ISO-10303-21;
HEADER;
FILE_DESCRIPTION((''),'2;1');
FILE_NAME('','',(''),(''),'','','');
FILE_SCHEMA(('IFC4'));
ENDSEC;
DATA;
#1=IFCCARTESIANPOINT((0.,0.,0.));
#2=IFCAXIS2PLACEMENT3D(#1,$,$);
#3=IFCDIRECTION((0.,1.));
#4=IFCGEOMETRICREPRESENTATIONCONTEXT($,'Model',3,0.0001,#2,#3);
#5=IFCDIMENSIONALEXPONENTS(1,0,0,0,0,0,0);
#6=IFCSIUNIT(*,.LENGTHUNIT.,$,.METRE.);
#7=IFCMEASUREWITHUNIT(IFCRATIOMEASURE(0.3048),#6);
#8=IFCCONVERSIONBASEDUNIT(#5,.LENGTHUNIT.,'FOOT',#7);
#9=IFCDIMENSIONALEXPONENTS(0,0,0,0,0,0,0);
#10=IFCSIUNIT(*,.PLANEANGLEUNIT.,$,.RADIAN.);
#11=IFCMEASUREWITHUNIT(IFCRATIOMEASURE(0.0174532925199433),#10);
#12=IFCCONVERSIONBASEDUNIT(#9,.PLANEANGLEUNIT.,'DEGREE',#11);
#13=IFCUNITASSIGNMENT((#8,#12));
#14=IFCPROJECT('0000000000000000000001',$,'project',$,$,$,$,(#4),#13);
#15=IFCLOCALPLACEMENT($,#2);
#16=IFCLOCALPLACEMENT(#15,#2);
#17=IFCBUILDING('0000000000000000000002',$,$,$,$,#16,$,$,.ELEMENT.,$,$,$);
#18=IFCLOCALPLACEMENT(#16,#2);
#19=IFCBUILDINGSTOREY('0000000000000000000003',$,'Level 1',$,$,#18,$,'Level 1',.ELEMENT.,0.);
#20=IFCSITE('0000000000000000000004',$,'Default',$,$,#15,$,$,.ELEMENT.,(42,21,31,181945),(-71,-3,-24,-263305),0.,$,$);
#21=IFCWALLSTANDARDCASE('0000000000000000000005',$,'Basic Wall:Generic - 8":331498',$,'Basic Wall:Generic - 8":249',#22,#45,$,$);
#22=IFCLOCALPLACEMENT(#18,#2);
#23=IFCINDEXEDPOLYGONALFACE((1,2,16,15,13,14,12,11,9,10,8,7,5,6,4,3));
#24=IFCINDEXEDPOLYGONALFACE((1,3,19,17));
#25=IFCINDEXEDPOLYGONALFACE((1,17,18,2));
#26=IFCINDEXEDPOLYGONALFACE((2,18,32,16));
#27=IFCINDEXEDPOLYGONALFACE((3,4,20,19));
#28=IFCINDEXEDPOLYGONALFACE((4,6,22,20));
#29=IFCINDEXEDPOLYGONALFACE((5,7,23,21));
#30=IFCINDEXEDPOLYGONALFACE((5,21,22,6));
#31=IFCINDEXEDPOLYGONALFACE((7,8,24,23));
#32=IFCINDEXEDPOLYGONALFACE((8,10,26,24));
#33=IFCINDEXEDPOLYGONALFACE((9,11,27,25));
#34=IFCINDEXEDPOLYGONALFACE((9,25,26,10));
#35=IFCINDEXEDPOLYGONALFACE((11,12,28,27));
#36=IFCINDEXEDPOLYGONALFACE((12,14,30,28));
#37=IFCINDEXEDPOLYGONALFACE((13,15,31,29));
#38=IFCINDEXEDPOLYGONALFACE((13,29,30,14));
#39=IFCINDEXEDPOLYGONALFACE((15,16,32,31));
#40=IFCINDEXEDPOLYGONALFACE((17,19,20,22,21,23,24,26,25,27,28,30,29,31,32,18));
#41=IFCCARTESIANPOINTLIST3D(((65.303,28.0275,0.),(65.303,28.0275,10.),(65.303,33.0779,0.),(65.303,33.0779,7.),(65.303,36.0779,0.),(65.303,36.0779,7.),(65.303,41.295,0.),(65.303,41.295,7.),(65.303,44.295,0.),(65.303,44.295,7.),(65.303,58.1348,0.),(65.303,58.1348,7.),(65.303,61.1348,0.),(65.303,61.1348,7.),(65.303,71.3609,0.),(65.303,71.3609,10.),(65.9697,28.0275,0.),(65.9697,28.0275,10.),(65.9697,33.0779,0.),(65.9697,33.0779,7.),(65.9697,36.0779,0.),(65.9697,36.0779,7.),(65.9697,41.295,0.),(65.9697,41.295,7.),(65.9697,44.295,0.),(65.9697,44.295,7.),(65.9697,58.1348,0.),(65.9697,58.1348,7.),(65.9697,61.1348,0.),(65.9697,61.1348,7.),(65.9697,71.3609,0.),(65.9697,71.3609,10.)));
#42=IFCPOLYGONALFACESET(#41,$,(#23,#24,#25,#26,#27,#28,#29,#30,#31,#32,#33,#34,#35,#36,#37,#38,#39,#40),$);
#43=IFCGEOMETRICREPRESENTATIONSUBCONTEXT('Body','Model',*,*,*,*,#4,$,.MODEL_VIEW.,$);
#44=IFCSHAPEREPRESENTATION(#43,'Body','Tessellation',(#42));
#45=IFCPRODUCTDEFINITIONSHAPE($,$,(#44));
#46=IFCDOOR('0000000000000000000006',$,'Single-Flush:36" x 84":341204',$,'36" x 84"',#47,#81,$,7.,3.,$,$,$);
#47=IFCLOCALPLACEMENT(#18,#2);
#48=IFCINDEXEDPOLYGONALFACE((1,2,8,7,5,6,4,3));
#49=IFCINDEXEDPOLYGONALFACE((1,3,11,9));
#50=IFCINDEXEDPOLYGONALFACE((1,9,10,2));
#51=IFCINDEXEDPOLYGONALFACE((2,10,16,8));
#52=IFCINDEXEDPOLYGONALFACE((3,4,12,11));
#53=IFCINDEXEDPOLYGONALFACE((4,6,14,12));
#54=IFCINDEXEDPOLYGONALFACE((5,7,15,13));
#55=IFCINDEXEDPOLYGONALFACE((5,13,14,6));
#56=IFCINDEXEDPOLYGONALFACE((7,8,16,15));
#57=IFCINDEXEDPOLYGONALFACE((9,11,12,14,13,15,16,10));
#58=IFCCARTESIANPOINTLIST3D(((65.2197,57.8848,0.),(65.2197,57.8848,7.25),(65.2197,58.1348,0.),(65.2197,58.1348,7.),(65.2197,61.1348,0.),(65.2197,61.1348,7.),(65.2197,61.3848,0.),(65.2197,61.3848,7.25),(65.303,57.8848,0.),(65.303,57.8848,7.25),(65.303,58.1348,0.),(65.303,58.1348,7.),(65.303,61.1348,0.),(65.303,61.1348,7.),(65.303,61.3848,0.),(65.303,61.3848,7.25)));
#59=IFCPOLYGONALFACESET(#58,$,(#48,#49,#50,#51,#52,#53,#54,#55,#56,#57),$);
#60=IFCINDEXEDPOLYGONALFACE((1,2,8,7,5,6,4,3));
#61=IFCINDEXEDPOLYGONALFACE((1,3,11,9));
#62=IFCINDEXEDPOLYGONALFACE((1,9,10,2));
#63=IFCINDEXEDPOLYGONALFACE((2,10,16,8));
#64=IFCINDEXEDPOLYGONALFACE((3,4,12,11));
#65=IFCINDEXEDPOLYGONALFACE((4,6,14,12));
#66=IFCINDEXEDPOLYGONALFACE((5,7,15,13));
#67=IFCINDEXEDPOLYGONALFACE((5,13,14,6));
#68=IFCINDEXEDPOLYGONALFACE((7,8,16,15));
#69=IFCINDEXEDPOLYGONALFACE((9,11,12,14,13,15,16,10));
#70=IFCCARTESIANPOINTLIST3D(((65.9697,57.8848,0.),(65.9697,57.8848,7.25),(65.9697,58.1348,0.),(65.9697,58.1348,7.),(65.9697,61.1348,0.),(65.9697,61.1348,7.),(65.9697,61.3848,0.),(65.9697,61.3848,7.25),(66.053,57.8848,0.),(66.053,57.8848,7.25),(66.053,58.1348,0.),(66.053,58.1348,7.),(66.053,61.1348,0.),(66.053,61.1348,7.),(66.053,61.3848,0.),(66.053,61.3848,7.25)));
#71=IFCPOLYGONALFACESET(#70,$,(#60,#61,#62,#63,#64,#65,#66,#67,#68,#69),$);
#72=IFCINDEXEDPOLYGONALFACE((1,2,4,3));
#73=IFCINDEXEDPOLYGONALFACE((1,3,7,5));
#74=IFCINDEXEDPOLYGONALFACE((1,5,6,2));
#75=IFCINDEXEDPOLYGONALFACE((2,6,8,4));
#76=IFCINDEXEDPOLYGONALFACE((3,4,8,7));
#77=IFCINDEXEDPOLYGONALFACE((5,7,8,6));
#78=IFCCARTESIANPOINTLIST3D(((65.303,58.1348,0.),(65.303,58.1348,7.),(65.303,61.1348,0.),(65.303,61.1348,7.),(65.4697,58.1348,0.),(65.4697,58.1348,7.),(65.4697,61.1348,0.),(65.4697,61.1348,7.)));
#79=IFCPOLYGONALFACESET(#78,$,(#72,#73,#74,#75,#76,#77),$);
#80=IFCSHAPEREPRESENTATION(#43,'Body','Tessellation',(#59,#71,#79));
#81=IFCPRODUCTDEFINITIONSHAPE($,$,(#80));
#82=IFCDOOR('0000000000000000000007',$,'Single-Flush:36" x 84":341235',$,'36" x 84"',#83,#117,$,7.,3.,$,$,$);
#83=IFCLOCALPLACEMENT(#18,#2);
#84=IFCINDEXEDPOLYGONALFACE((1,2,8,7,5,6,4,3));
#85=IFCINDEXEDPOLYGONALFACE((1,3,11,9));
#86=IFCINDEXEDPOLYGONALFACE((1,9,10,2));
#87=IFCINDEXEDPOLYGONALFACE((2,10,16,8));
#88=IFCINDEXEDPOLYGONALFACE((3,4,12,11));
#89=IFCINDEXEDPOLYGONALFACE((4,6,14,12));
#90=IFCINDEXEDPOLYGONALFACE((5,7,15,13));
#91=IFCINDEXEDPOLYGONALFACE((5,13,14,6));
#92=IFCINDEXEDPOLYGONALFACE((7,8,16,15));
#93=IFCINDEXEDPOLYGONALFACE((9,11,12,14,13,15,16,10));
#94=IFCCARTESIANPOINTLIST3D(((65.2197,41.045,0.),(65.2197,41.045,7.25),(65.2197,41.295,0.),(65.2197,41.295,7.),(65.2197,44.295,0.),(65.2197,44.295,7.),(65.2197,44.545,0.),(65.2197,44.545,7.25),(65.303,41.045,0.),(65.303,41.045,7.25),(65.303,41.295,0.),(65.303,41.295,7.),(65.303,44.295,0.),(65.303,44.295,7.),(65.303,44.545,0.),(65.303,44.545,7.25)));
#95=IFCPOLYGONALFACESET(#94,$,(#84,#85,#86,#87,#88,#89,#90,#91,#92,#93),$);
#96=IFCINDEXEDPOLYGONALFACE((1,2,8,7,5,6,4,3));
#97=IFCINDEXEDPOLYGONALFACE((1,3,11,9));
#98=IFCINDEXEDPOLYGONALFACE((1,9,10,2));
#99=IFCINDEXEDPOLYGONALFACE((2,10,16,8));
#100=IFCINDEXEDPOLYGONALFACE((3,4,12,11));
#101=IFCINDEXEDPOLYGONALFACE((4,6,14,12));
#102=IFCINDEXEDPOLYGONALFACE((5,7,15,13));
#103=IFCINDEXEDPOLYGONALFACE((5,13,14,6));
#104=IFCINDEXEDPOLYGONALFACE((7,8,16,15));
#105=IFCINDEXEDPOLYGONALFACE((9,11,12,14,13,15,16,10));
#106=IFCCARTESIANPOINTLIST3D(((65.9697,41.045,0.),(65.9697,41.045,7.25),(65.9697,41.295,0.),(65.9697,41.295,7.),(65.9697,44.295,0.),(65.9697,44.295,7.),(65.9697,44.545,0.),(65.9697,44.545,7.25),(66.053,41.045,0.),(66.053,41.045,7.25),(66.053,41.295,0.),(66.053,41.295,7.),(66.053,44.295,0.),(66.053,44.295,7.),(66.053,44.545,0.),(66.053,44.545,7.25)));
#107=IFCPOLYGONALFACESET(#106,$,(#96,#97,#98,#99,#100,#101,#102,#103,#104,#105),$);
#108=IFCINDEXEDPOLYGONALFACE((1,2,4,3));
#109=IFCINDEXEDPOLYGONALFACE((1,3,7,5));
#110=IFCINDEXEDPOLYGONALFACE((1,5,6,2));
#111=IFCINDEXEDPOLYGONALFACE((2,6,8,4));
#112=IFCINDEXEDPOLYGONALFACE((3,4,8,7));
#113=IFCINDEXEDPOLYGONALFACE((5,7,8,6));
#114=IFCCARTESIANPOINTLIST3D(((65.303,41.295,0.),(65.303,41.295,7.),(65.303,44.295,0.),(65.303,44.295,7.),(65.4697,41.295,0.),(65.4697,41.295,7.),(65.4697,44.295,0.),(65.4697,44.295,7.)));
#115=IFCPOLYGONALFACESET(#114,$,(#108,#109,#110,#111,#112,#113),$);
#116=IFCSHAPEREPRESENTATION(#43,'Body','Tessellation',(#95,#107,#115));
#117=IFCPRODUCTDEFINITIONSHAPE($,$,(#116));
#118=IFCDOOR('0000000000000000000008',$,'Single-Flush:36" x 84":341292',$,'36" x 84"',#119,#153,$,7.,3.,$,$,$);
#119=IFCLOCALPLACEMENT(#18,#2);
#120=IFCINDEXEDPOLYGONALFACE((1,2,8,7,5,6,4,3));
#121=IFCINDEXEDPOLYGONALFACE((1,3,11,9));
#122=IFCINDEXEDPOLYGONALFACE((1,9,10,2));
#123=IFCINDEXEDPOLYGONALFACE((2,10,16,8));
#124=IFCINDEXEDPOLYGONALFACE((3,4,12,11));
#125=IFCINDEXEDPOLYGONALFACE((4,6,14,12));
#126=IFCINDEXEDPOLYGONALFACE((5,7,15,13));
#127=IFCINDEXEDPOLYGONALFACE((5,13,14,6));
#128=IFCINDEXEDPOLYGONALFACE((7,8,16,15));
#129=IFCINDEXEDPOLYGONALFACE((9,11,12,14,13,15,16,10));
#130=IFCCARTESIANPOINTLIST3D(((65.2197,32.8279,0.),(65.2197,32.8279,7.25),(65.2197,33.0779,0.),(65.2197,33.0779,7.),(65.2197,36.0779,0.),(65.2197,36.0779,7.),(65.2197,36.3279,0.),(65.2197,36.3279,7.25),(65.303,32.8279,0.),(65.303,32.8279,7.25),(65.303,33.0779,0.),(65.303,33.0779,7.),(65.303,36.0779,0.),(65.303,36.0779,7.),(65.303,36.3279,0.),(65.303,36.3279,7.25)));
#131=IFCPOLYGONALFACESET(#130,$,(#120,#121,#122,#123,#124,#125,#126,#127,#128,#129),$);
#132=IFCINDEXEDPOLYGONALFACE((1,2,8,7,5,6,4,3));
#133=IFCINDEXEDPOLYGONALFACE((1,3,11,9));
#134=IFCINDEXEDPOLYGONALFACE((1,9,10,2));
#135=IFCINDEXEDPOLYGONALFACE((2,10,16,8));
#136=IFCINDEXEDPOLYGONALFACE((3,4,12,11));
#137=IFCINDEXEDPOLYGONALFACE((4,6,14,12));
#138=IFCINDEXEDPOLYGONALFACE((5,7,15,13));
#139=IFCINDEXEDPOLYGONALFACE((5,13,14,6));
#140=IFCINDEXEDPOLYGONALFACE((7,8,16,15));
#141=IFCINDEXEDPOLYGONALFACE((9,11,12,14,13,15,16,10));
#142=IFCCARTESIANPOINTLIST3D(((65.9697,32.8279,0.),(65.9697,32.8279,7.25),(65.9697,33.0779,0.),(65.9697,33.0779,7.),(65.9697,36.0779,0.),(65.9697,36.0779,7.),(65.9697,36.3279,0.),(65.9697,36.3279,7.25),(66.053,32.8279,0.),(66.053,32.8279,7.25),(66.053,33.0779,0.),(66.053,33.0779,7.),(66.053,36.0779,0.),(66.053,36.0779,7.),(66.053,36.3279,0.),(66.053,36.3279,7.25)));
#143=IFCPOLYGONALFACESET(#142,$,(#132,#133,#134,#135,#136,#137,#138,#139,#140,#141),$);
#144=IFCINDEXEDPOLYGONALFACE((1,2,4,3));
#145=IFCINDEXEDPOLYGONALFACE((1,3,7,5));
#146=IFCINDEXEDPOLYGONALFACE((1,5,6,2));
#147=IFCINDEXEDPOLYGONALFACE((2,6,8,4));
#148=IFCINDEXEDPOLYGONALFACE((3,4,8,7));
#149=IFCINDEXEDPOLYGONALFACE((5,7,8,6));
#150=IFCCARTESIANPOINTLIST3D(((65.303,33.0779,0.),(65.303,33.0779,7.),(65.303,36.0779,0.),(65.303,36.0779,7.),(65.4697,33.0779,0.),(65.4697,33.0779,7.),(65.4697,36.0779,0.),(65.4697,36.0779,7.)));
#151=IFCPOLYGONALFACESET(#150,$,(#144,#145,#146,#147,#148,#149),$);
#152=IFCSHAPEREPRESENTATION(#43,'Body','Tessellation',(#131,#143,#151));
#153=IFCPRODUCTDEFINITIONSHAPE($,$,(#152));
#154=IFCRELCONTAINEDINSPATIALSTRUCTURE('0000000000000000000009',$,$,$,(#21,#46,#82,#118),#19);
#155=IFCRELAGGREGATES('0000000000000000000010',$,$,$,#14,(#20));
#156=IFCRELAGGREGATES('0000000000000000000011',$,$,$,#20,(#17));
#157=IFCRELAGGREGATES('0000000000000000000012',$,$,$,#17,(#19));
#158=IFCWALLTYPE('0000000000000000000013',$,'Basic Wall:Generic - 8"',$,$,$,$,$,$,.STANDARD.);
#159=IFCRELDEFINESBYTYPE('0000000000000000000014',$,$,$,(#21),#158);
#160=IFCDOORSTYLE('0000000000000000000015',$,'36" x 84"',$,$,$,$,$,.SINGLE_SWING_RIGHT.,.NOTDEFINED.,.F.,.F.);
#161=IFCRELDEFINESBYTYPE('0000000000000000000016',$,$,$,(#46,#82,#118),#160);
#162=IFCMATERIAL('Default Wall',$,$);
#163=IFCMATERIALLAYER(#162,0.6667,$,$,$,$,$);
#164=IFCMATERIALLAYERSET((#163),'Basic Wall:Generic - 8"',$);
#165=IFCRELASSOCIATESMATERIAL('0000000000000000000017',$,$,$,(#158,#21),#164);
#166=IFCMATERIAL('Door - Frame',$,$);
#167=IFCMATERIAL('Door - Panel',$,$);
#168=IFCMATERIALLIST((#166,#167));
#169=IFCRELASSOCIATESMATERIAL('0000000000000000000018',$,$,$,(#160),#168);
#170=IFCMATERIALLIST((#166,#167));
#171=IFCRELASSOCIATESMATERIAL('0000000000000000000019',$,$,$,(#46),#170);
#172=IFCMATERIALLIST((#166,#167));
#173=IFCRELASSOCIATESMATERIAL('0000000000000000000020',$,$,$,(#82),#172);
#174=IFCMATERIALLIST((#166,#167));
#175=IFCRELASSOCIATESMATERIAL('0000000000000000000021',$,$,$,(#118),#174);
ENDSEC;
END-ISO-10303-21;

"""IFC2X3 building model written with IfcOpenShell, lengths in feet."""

from ifc_helpers import new_model, entity, si_unit, converted_unit, direction, frame, frame_2d, origin, place, context, subcontext, project, spatial, polyline, rectangle, outline, extrude, source, transform, mapped, material, material_list, layer, layer_set, layer_usage, type_object, type_shapes, element, fill, save


model = new_model("IFC2X3")

# Units and contexts
model_context = context("Model", 3, precision=0.0001, world=origin(), true_north=direction((0.0, 1.0)))
body_context = subcontext(model_context, "Body", "Model", "MODEL_VIEW")
ifc_project = project(units=[converted_unit("LENGTHUNIT", "FOOT", entity("IfcRatioMeasure", 0.3048), si_unit("LENGTHUNIT", "METRE"), dimensions=[1, 0, 0, 0, 0, 0, 0]), converted_unit("PLANEANGLEUNIT", "DEGREE", entity("IfcRatioMeasure", 0.0174532925199433), si_unit("PLANEANGLEUNIT", "RADIAN"), dimensions=[0, 0, 0, 0, 0, 0, 0])], contexts=[model_context])

# Site, building, storey
site_placement = place(None, origin())
site = spatial("IfcSite", under=ifc_project, at=site_placement, Name="Default", CompositionType="ELEMENT", RefLatitude=(42, 21, 31, 181945), RefLongitude=(-71, -3, -24, -263305), RefElevation=0.0)
building_placement = place(site_placement, origin())
building = spatial("IfcBuilding", under=site, at=building_placement, CompositionType="ELEMENT")
storey_placement = place(building_placement, origin())
storey = spatial("IfcBuildingStorey", under=building, at=storey_placement, Name="Level 1", LongName="Level 1", CompositionType="ELEMENT", Elevation=0.0)

# Wall, openings, doors
ifc_material_1 = material(Name="Default Wall")
ifc_layer = layer(ifc_material_1, 0.6667)
ifc_layer_set = layer_set([ifc_layer], Name="Basic Wall:Generic - 8\"")
ifc_layer_usage_1 = layer_usage(ifc_layer_set, "AXIS2", "NEGATIVE", 0.3333)
wall_type = type_object("IfcWallType", Name="Basic Wall:Generic - 8\"", PredefinedType="STANDARD", material=ifc_layer_set)
wall_1_placement = place(storey_placement, frame((65.6363, 28.0275, 0.0), z_axis=(0.0, 0.0, 1.0), x_axis=(0.0, 1.0, 0.0)))
wall_1 = element("IfcWallStandardCase", 1, at=wall_1_placement, inside=storey, type_object=wall_type, material=ifc_layer_usage_1, Name="Basic Wall:Generic - 8\":331498", ObjectType="Basic Wall:Generic - 8\":249", context=body_context, shape_type="SweptSolid", body=[
    extrude(rectangle(XDim=43.3333, YDim=0.6667, at=frame_2d((21.6667, 0.0), x_axis=(-1.0, 0.0))), origin(), (0.0, 0.0, 1.0), 10.0),
])
opening_1_placement = place(wall_1_placement, frame((30.1072, -0.3333, 0.0)))
opening_1 = element("IfcOpeningElement", 2, at=opening_1_placement, cuts=wall_1, ObjectType="Opening", context=body_context, shape_type="SweptSolid", body=[
    extrude(rectangle(XDim=3.0, YDim=7.0, at=frame_2d((3.5, 1.5), x_axis=(0.0, 1.0))), frame((0.0, 0.0, 0.0), z_axis=(0.0, 1.0, 0.0), x_axis=(0.0, 0.0, 1.0)), (0.0, 0.0, 1.0), 0.6667),
])
opening_2_placement = place(wall_1_placement, frame((13.2675, -0.3333, 0.0)))
opening_2 = element("IfcOpeningElement", 3, at=opening_2_placement, cuts=wall_1, ObjectType="Opening", context=body_context, shape_type="SweptSolid", body=[
    extrude(rectangle(XDim=3.0, YDim=7.0, at=frame_2d((3.5, 1.5), x_axis=(0.0, 1.0))), frame((0.0, 0.0, 0.0), z_axis=(0.0, 1.0, 0.0), x_axis=(0.0, 0.0, 1.0)), (0.0, 0.0, 1.0), 0.6667),
])
opening_3_placement = place(wall_1_placement, frame((5.0504, -0.3333, 0.0)))
opening_3 = element("IfcOpeningElement", 4, at=opening_3_placement, cuts=wall_1, ObjectType="Opening", context=body_context, shape_type="SweptSolid", body=[
    extrude(rectangle(XDim=3.0, YDim=7.0, at=frame_2d((3.5, 1.5), x_axis=(0.0, 1.0))), frame((0.0, 0.0, 0.0), z_axis=(0.0, 1.0, 0.0), x_axis=(0.0, 0.0, 1.0)), (0.0, 0.0, 1.0), 0.6667),
])
ifc_material_2 = material(Name="Door - Frame")
ifc_material_3 = material(Name="Door - Panel")
ifc_material_list_1 = material_list([ifc_material_2, ifc_material_3])
ifc_material_list_2 = material_list([ifc_material_2, ifc_material_3])
door_style = type_object("IfcDoorStyle", Name="36\" x 84\"", ConstructionType="NOTDEFINED", OperationType="SINGLE_SWING_RIGHT", ParameterTakesPrecedence=False, Sizeable=False, material=ifc_material_list_2)
shared_shape = source(origin(), body_context, "Body", "SweptSolid", [
    extrude(outline(polyline([(-1.75, -3.6875), (1.75, -3.6875), (1.75, 3.5625), (1.5, 3.5625), (1.5, -3.4375), (-1.5, -3.4375), (-1.5, 3.5625), (-1.75, 3.5625), (-1.75, -3.6875)])), frame((1.5, 0.6667, 3.5625), z_axis=(0.0, 1.0, 0.0), x_axis=(1.0, 0.0, 0.0)), (0.0, 0.0, 1.0), 0.0833),
    extrude(outline(polyline([(-3.6875, -1.75), (3.5625, -1.75), (3.5625, -1.5), (-3.4375, -1.5), (-3.4375, 1.5), (3.5625, 1.5), (3.5625, 1.75), (-3.6875, 1.75), (-3.6875, -1.75)])), frame((1.5, -0.0833, 3.5625), z_axis=(0.0, 1.0, 0.0), x_axis=(0.0, 0.0, -1.0)), (0.0, 0.0, 1.0), 0.0833),
    extrude(rectangle(XDim=0.1667, YDim=3.0, at=frame_2d((0.0, 0.0), x_axis=(1.0, 0.0))), frame((1.5, 0.5833, 0.0), z_axis=(0.0, 0.0, 1.0), x_axis=(0.0, 1.0, 0.0)), (0.0, 0.0, 1.0), 7.0),
])
type_shapes(door_style, [shared_shape])
door_1_placement = place(opening_1_placement, origin())
door_1 = element("IfcDoor", 5, at=door_1_placement, inside=storey, type_object=door_style, material=ifc_material_list_1, Name="Single-Flush:36\" x 84\":341204", ObjectType="36\" x 84\"", OverallHeight=7.0, OverallWidth=3.0, context=body_context, shape_type="MappedRepresentation", body=[
    mapped(shared_shape, transform((0.0, 0.0, 0.0), scale=1.0)),
])
fill(opening_1, door_1)
ifc_material_list_3 = material_list([ifc_material_2, ifc_material_3])
door_2_placement = place(opening_2_placement, origin())
door_2 = element("IfcDoor", 6, at=door_2_placement, inside=storey, type_object=door_style, material=ifc_material_list_3, Name="Single-Flush:36\" x 84\":341235", ObjectType="36\" x 84\"", OverallHeight=7.0, OverallWidth=3.0, context=body_context, shape_type="MappedRepresentation", body=[
    mapped(shared_shape, transform((0.0, 0.0, 0.0), scale=1.0)),
])
fill(opening_2, door_2)
ifc_material_list_4 = material_list([ifc_material_2, ifc_material_3])
door_3_placement = place(opening_3_placement, origin())
door_3 = element("IfcDoor", 7, at=door_3_placement, inside=storey, type_object=door_style, material=ifc_material_list_4, Name="Single-Flush:36\" x 84\":341292", ObjectType="36\" x 84\"", OverallHeight=7.0, OverallWidth=3.0, context=body_context, shape_type="MappedRepresentation", body=[
    mapped(shared_shape, transform((0.0, 0.0, 0.0), scale=1.0)),
])
fill(opening_3, door_3)

save(model, "model.ifc")
